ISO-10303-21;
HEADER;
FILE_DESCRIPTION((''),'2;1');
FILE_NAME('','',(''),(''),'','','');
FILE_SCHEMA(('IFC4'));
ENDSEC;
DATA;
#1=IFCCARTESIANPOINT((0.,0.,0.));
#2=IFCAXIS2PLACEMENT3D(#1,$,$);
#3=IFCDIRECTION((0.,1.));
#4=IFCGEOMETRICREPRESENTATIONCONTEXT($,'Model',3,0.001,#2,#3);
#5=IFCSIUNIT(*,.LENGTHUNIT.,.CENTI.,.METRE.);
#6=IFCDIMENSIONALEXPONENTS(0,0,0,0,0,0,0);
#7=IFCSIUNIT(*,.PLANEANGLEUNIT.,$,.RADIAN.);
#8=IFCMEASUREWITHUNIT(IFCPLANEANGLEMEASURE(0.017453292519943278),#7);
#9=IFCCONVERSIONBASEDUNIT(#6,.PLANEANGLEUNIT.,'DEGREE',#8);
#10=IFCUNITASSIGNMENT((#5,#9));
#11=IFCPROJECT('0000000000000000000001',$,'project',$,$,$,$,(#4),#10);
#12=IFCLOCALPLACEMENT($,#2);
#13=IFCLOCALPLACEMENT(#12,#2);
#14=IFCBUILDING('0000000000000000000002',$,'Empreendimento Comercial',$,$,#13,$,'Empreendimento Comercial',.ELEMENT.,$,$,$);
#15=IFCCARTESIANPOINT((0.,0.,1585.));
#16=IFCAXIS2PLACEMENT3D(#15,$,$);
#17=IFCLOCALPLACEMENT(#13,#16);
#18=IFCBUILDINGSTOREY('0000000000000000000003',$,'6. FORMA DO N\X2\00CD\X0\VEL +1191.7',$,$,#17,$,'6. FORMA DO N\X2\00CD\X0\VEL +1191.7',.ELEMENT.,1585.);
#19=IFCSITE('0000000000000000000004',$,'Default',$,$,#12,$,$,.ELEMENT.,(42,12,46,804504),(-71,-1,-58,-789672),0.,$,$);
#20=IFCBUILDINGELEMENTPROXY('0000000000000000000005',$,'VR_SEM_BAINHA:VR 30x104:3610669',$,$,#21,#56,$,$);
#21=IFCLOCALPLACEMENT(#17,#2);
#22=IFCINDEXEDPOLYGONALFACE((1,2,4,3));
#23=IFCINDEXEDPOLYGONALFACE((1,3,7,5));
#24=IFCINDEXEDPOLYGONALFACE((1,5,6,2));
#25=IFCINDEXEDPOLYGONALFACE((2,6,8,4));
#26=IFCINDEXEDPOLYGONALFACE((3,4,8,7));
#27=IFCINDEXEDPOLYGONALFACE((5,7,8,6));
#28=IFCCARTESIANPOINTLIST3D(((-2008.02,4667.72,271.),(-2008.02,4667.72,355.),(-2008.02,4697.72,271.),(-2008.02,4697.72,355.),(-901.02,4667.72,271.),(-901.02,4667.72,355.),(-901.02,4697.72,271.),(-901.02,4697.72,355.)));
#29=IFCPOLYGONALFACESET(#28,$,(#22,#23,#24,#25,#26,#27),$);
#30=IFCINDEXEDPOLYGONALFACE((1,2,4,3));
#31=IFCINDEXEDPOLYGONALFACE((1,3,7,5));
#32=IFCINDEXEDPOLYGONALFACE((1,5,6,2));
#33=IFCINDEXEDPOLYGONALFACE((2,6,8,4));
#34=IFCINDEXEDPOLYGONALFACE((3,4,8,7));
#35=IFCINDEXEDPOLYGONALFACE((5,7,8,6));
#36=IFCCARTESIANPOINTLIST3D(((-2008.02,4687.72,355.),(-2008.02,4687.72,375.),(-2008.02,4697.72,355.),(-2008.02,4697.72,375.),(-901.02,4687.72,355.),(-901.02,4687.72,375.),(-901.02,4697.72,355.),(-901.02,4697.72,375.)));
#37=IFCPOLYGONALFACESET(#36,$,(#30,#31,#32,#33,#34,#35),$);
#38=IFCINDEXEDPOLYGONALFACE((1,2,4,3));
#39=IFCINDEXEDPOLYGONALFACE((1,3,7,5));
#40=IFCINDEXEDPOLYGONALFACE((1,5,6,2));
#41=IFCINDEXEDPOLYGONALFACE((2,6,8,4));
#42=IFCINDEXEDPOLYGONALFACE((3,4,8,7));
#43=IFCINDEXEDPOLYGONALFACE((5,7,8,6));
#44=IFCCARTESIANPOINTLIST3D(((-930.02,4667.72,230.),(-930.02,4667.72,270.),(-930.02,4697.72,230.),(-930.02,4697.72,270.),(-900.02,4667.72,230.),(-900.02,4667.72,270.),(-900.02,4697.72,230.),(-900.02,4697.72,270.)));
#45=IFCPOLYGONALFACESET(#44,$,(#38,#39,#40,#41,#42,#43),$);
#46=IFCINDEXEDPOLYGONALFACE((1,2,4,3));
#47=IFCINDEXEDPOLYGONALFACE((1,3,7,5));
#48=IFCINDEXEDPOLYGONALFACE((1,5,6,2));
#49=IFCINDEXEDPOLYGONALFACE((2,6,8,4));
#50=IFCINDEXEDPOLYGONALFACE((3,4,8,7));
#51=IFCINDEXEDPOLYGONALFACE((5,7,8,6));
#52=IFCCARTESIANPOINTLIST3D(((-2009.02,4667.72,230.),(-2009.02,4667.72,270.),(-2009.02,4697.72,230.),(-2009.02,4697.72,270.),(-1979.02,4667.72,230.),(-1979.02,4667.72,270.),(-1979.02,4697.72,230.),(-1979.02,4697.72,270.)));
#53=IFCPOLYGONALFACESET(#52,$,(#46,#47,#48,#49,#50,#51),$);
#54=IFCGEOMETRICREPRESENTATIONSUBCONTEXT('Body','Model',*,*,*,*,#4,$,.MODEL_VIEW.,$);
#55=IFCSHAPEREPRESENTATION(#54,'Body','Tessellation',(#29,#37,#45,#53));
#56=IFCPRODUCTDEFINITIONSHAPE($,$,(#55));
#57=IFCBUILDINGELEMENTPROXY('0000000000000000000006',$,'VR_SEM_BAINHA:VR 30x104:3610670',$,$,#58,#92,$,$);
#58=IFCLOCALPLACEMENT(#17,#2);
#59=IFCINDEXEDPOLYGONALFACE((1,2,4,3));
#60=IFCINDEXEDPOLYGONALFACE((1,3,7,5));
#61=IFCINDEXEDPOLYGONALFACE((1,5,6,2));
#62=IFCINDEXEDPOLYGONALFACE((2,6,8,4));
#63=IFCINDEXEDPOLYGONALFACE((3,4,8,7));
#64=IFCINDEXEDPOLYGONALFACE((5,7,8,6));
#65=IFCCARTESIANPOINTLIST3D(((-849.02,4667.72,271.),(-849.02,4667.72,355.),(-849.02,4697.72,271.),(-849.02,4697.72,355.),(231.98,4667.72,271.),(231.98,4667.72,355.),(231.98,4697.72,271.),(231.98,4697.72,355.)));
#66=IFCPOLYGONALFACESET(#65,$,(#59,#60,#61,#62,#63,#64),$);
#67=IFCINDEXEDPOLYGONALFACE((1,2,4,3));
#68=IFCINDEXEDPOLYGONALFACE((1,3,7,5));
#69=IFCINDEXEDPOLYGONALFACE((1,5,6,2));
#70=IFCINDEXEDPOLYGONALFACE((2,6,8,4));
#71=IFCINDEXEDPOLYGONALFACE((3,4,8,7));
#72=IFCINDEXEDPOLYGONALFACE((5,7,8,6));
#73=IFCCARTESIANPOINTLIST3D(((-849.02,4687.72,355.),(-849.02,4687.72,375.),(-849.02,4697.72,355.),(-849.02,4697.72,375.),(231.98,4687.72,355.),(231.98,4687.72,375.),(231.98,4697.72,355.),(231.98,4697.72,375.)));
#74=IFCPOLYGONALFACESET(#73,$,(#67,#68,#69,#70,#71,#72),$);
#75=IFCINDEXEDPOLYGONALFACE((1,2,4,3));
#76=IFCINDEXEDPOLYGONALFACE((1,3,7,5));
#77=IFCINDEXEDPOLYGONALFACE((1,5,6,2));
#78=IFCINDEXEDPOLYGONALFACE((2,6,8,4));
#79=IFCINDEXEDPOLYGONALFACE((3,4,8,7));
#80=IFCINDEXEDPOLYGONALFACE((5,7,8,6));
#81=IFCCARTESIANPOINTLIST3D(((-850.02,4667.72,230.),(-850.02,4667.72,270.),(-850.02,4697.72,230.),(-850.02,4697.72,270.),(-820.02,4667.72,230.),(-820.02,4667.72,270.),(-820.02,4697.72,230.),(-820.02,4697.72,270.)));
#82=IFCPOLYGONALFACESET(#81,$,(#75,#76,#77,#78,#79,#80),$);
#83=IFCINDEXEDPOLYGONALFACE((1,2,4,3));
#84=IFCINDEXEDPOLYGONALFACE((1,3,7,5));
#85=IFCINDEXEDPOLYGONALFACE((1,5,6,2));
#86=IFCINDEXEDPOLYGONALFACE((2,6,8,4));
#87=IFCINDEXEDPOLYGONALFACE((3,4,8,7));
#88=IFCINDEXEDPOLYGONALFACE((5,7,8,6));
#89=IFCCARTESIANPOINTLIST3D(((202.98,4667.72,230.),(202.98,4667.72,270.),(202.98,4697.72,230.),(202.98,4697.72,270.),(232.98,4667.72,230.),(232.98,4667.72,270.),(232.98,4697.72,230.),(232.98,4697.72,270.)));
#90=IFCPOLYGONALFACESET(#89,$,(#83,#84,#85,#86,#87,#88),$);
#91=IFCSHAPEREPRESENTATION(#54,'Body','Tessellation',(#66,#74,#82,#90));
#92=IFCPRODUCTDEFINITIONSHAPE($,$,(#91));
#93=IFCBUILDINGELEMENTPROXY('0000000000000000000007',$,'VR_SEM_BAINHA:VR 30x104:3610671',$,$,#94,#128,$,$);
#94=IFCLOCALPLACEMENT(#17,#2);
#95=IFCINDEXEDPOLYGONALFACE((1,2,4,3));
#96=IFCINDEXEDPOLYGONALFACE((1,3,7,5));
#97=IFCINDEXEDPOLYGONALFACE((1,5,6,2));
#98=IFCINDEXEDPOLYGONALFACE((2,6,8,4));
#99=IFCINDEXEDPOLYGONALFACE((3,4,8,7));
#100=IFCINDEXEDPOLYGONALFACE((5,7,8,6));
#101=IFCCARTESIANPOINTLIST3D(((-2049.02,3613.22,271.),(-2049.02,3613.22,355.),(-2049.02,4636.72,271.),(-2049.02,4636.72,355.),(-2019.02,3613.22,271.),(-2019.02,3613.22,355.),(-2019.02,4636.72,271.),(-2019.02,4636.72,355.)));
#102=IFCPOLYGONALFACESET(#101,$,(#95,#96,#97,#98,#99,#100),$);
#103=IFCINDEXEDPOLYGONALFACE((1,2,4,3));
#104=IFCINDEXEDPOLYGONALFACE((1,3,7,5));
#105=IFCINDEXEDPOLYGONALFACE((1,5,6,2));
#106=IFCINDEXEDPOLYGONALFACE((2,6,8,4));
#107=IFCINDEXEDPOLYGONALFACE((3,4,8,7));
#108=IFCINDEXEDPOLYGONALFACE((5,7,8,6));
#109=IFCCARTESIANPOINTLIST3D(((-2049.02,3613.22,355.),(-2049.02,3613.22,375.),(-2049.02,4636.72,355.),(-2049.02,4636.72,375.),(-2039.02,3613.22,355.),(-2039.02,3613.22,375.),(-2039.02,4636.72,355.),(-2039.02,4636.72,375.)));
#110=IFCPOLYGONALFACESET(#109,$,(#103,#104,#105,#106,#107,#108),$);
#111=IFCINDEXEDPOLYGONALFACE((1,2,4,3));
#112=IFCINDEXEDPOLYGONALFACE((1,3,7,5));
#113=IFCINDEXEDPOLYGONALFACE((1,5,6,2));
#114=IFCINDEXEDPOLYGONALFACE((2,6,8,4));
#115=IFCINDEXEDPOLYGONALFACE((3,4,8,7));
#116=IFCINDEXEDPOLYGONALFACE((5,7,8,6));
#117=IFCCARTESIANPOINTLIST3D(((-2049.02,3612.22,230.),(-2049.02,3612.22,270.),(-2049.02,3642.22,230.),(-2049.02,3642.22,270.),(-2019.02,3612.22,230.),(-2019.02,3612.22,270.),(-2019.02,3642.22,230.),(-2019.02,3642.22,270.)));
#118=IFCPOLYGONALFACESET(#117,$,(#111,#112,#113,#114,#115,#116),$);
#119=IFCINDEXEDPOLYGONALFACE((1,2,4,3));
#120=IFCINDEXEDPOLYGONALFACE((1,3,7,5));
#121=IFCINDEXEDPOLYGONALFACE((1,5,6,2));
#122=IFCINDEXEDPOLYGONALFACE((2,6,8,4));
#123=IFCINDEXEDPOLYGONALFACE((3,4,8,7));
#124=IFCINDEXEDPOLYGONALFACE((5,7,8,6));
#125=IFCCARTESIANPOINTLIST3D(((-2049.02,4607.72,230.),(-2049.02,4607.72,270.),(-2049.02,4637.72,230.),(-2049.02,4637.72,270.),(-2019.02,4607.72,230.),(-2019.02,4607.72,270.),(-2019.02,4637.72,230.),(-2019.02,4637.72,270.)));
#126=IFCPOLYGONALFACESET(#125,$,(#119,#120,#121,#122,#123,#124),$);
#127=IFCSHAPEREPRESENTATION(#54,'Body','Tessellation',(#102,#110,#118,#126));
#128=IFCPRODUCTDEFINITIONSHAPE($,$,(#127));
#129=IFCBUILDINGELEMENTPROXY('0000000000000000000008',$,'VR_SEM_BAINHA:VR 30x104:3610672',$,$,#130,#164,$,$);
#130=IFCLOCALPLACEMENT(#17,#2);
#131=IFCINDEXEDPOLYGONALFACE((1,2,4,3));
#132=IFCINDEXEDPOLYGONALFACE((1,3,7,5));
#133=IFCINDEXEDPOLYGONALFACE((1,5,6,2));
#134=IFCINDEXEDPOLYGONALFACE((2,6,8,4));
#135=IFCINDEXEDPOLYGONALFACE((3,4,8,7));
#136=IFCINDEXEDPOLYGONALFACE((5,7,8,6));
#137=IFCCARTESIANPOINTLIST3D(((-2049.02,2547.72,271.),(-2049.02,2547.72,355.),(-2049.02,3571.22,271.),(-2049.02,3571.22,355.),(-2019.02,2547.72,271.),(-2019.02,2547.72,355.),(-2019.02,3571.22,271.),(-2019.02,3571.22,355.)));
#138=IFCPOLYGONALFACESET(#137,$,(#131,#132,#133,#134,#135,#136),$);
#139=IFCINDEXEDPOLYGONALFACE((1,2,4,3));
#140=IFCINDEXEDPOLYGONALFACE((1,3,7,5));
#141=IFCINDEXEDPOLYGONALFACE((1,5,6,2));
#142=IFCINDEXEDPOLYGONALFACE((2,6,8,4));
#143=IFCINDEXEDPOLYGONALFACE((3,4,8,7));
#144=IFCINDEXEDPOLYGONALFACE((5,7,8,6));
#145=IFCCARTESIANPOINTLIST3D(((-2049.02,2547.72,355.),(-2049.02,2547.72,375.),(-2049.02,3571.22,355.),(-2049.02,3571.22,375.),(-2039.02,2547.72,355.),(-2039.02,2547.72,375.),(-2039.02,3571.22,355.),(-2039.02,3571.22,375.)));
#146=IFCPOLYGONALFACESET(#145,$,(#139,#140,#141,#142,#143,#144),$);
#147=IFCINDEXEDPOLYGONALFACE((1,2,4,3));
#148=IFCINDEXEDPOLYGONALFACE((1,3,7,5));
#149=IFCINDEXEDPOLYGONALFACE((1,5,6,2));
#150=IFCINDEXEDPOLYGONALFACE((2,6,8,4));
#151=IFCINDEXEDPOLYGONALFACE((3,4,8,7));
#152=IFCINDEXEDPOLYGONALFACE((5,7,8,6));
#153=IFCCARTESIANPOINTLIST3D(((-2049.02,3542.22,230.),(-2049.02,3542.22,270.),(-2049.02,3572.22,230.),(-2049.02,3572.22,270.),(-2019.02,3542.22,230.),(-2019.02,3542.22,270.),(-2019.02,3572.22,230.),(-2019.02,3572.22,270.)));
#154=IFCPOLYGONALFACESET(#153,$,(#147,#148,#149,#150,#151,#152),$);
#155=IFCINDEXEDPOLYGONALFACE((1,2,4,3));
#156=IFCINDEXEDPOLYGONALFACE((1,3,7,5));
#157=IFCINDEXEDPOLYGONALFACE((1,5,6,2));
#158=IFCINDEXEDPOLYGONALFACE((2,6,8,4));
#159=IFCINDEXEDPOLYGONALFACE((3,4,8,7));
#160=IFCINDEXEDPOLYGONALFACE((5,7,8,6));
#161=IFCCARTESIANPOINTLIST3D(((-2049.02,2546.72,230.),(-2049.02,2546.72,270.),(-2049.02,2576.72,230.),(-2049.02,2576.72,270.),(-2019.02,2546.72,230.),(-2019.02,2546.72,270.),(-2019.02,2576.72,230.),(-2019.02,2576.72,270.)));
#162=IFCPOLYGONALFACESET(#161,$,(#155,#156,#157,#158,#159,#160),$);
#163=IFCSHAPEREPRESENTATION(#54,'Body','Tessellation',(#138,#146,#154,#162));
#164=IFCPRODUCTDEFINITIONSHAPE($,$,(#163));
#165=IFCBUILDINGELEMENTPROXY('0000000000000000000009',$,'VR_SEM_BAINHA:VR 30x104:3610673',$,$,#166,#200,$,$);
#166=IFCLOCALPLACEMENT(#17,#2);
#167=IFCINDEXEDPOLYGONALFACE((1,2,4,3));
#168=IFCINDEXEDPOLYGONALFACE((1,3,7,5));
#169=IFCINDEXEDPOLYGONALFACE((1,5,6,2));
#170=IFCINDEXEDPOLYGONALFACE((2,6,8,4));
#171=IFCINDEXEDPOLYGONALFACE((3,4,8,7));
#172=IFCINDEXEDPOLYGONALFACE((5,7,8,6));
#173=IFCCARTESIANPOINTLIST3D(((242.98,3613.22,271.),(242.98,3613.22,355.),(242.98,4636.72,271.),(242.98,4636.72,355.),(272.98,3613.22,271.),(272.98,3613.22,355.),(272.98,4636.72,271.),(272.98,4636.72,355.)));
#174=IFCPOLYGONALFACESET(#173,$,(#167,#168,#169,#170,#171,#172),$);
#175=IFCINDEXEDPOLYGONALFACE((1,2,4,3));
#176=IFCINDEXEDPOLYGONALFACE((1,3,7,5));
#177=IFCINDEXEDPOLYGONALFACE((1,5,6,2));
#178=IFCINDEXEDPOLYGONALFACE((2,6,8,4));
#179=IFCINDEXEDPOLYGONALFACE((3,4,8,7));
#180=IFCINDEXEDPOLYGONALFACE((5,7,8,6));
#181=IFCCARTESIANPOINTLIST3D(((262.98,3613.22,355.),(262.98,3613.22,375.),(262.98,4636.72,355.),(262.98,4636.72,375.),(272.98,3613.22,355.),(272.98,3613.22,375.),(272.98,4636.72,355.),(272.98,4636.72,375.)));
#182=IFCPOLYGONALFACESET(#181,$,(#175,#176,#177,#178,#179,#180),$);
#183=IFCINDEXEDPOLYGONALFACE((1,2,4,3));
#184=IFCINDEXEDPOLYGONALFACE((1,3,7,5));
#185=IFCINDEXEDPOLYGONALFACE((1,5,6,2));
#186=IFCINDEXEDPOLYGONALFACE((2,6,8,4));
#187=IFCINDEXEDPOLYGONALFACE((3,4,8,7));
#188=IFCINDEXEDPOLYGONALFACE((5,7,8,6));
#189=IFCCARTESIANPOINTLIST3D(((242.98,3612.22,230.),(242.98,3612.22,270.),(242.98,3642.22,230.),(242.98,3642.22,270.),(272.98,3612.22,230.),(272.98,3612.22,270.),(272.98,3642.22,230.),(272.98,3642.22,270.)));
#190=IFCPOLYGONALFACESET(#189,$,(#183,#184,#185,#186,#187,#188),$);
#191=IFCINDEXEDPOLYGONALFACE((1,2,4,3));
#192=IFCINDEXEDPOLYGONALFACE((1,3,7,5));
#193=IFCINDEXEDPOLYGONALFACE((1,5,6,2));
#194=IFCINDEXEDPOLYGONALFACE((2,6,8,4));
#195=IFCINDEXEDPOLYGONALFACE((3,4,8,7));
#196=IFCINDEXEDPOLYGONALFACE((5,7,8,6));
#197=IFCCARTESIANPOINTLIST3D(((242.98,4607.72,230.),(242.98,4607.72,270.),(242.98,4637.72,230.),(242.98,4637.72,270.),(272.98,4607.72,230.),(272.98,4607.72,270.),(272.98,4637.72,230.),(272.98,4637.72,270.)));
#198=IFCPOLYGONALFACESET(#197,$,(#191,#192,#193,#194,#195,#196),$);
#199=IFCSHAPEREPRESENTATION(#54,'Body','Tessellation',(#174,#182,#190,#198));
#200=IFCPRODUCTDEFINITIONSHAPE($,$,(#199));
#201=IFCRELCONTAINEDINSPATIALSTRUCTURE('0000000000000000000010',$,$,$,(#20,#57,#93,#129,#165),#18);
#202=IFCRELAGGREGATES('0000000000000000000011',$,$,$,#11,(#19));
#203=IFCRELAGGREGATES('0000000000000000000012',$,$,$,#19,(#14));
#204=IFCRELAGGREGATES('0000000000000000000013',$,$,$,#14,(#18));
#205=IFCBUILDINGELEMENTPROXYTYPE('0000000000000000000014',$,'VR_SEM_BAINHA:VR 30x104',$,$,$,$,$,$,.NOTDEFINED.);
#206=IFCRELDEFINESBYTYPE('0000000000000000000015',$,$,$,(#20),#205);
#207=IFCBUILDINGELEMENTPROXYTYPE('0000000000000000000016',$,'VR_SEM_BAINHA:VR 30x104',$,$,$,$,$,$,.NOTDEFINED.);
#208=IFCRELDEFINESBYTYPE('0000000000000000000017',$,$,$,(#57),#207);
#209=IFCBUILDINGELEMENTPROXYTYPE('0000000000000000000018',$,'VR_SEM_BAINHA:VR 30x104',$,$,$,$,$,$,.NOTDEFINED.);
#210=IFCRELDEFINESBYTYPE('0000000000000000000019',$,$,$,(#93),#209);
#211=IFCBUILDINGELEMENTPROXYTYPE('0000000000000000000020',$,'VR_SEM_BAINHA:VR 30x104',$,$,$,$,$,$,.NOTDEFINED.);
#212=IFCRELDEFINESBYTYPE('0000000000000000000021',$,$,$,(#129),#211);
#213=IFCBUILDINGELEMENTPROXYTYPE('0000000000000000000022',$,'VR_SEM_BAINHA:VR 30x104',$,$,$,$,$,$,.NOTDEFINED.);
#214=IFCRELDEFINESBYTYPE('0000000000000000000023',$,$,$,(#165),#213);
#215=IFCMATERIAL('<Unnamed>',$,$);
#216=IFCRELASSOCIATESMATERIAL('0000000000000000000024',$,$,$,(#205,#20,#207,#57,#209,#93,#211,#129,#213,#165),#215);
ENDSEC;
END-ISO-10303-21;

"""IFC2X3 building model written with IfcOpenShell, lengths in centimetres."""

from ifc_helpers import new_model, entity, si_unit, converted_unit, direction, frame, frame_2d, origin, origin_2d_with_axis, place, context, subcontext, project, spatial, rectangle, extrude, source, transform, mapped, material, type_object, type_shapes, element, save


model = new_model("IFC2X3")

# Units and contexts
model_context = context("Model", 3, precision=0.001, world=origin(), true_north=direction((0.0, 1.0)))
body_context = subcontext(model_context, "Body", "Model", "MODEL_VIEW")
ifc_project = project(units=[si_unit("LENGTHUNIT", "METRE", prefix="CENTI"), converted_unit("PLANEANGLEUNIT", "DEGREE", entity("IfcPlaneAngleMeasure", 0.017453292519943278), si_unit("PLANEANGLEUNIT", "RADIAN"), dimensions=[0, 0, 0, 0, 0, 0, 0])], contexts=[model_context])

# Site, building, storey
site_placement = place(None, origin())
site = spatial("IfcSite", under=ifc_project, at=site_placement, Name="Default", CompositionType="ELEMENT", RefLatitude=(42, 12, 46, 804504), RefLongitude=(-71, -1, -58, -789672), RefElevation=0.0)
building_placement = place(site_placement, origin())
building = spatial("IfcBuilding", under=site, at=building_placement, Name="Empreendimento Comercial", LongName="Empreendimento Comercial", CompositionType="ELEMENT")
storey_placement = place(building_placement, frame((0.0, 0.0, 1585.0)))
storey = spatial("IfcBuildingStorey", under=building, at=storey_placement, Name="6. FORMA DO NÍVEL +1191.7", LongName="6. FORMA DO NÍVEL +1191.7", CompositionType="ELEMENT", Elevation=1585.0)

# Shared definitions
ifc_material = material(Name="<Unnamed>")

# Building element proxies
building_element_proxy_type_1 = type_object("IfcBuildingElementProxyType", Name="VR_SEM_BAINHA:VR 30x104", PredefinedType="NOTDEFINED", material=ifc_material)
shared_shape_1 = source(origin(), body_context, "Body", "SweptSolid", [
    extrude(rectangle(XDim=30.0, YDim=1107.0, at=frame_2d((0.0, 0.0), x_axis=(1.0, 0.0))), frame((-1454.52, 4682.72, 1856.0), z_axis=(0.0, 0.0, 1.0), x_axis=(0.0, -1.0, 0.0)), (0.0, 0.0, 1.0), 84.0),
    extrude(rectangle(XDim=10.0, YDim=1107.0, at=frame_2d((0.0, 0.0), x_axis=(1.0, 0.0))), frame((-1454.52, 4692.72, 1940.0), z_axis=(0.0, 0.0, 1.0), x_axis=(0.0, -1.0, 0.0)), (0.0, 0.0, 1.0), 20.0),
    extrude(rectangle(XDim=30.0, YDim=30.0, at=frame_2d((0.0, 0.0), x_axis=(1.0, 0.0))), frame((-915.02, 4682.72, 1815.0)), (0.0, 0.0, 1.0), 40.0),
    extrude(rectangle(XDim=30.0, YDim=30.0, at=origin_2d_with_axis()), frame((-1994.02, 4682.72, 1815.0)), (0.0, 0.0, 1.0), 40.0),
])
type_shapes(building_element_proxy_type_1, [shared_shape_1])
proxy_1_placement = place(storey_placement, frame((0.0, 0.0, -1585.0)))
element("IfcBuildingElementProxy", 1, at=proxy_1_placement, inside=storey, type_object=building_element_proxy_type_1, material=ifc_material, Name="VR_SEM_BAINHA:VR 30x104:3610669", context=body_context, shape_type="MappedRepresentation", body=[
    mapped(shared_shape_1, transform((0.0, 0.0, 0.0), scale=1.0)),
])
building_element_proxy_type_2 = type_object("IfcBuildingElementProxyType", Name="VR_SEM_BAINHA:VR 30x104", PredefinedType="NOTDEFINED", material=ifc_material)
shared_shape_2 = source(origin(), body_context, "Body", "SweptSolid", [
    extrude(rectangle(XDim=1081.0, YDim=30.0, at=frame_2d((0.0, 0.0), x_axis=(1.0, 0.0))), frame((-308.52, 4682.72, 1856.0), z_axis=(0.0, 0.0, 1.0), x_axis=(-1.0, 0.0, 0.0)), (0.0, 0.0, 1.0), 84.0),
    extrude(rectangle(XDim=1081.0, YDim=10.0, at=origin_2d_with_axis()), frame((-308.52, 4692.72, 1940.0), z_axis=(0.0, 0.0, 1.0), x_axis=(-1.0, 0.0, 0.0)), (0.0, 0.0, 1.0), 20.0),
    extrude(rectangle(XDim=30.0, YDim=30.0, at=origin_2d_with_axis()), frame((-835.02, 4682.72, 1815.0), z_axis=(0.0, 0.0, 1.0), x_axis=(0.0, 1.0, 0.0)), (0.0, 0.0, 1.0), 40.0),
    extrude(rectangle(XDim=30.0, YDim=30.0, at=origin_2d_with_axis()), frame((217.98, 4682.72, 1815.0), z_axis=(0.0, 0.0, 1.0), x_axis=(0.0, 1.0, 0.0)), (0.0, 0.0, 1.0), 40.0),
])
type_shapes(building_element_proxy_type_2, [shared_shape_2])
proxy_2_placement = place(storey_placement, frame((0.0, 0.0, -1585.0)))
element("IfcBuildingElementProxy", 2, at=proxy_2_placement, inside=storey, type_object=building_element_proxy_type_2, material=ifc_material, Name="VR_SEM_BAINHA:VR 30x104:3610670", context=body_context, shape_type="MappedRepresentation", body=[
    mapped(shared_shape_2, transform((0.0, 0.0, 0.0), scale=1.0)),
])
building_element_proxy_type_3 = type_object("IfcBuildingElementProxyType", Name="VR_SEM_BAINHA:VR 30x104", PredefinedType="NOTDEFINED", material=ifc_material)
shared_shape_3 = source(origin(), body_context, "Body", "SweptSolid", [
    extrude(rectangle(XDim=1023.5, YDim=30.0, at=frame_2d((0.0, 0.0), x_axis=(1.0, 0.0))), frame((-2034.02, 4124.97, 1856.0), z_axis=(0.0, 0.0, 1.0), x_axis=(0.0, -1.0, 0.0)), (0.0, 0.0, 1.0), 84.0),
    extrude(rectangle(XDim=1023.5, YDim=10.0, at=frame_2d((0.0, 0.0), x_axis=(1.0, 0.0))), frame((-2044.02, 4124.97, 1940.0), z_axis=(0.0, 0.0, 1.0), x_axis=(0.0, -1.0, 0.0)), (0.0, 0.0, 1.0), 20.0),
    extrude(rectangle(XDim=30.0, YDim=30.0, at=frame_2d((0.0, 0.0), x_axis=(1.0, 0.0))), frame((-2034.02, 3627.22, 1815.0), z_axis=(0.0, 0.0, 1.0), x_axis=(-1.0, 0.0, 0.0)), (0.0, 0.0, 1.0), 40.0),
    extrude(rectangle(XDim=30.0, YDim=30.0, at=frame_2d((0.0, 0.0), x_axis=(1.0, 0.0))), frame((-2034.02, 4622.72, 1815.0), z_axis=(0.0, 0.0, 1.0), x_axis=(-1.0, 0.0, 0.0)), (0.0, 0.0, 1.0), 40.0),
])
type_shapes(building_element_proxy_type_3, [shared_shape_3])
proxy_3_placement = place(storey_placement, frame((0.0, 0.0, -1585.0)))
element("IfcBuildingElementProxy", 3, at=proxy_3_placement, inside=storey, type_object=building_element_proxy_type_3, material=ifc_material, Name="VR_SEM_BAINHA:VR 30x104:3610671", context=body_context, shape_type="MappedRepresentation", body=[
    mapped(shared_shape_3, transform((0.0, 0.0, 0.0), scale=1.0)),
])
building_element_proxy_type_4 = type_object("IfcBuildingElementProxyType", Name="VR_SEM_BAINHA:VR 30x104", PredefinedType="NOTDEFINED", material=ifc_material)
shared_shape_4 = source(origin(), body_context, "Body", "SweptSolid", [
    extrude(rectangle(XDim=30.0, YDim=1023.5, at=frame_2d((0.0, 0.0), x_axis=(1.0, 0.0))), frame((-2034.02, 3059.47, 1856.0)), (0.0, 0.0, 1.0), 84.0),
    extrude(rectangle(XDim=10.0, YDim=1023.5, at=frame_2d((0.0, 0.0), x_axis=(1.0, 0.0))), frame((-2044.02, 3059.47, 1940.0)), (0.0, 0.0, 1.0), 20.0),
    extrude(rectangle(XDim=30.0, YDim=30.0, at=frame_2d((0.0, 0.0), x_axis=(1.0, 0.0))), frame((-2034.02, 3557.22, 1815.0), z_axis=(0.0, 0.0, 1.0), x_axis=(0.0, 1.0, 0.0)), (0.0, 0.0, 1.0), 40.0),
    extrude(rectangle(XDim=30.0, YDim=30.0, at=origin_2d_with_axis()), frame((-2034.02, 2561.72, 1815.0), z_axis=(0.0, 0.0, 1.0), x_axis=(0.0, 1.0, 0.0)), (0.0, 0.0, 1.0), 40.0),
])
type_shapes(building_element_proxy_type_4, [shared_shape_4])
proxy_4_placement = place(storey_placement, frame((0.0, 0.0, -1585.0)))
element("IfcBuildingElementProxy", 4, at=proxy_4_placement, inside=storey, type_object=building_element_proxy_type_4, material=ifc_material, Name="VR_SEM_BAINHA:VR 30x104:3610672", context=body_context, shape_type="MappedRepresentation", body=[
    mapped(shared_shape_4, transform((0.0, 0.0, 0.0), scale=1.0)),
])
building_element_proxy_type_5 = type_object("IfcBuildingElementProxyType", Name="VR_SEM_BAINHA:VR 30x104", PredefinedType="NOTDEFINED", material=ifc_material)
shared_shape_5 = source(origin(), body_context, "Body", "SweptSolid", [
    extrude(rectangle(XDim=30.0, YDim=1023.5, at=frame_2d((0.0, 0.0), x_axis=(1.0, 0.0))), frame((257.98, 4124.97, 1856.0), z_axis=(0.0, 0.0, 1.0), x_axis=(-1.0, 0.0, 0.0)), (0.0, 0.0, 1.0), 84.0),
    extrude(rectangle(XDim=10.0, YDim=1023.5, at=frame_2d((0.0, 0.0), x_axis=(1.0, 0.0))), frame((267.98, 4124.97, 1940.0), z_axis=(0.0, 0.0, 1.0), x_axis=(-1.0, 0.0, 0.0)), (0.0, 0.0, 1.0), 20.0),
    extrude(rectangle(XDim=30.0, YDim=30.0, at=frame_2d((0.0, 0.0), x_axis=(1.0, 0.0))), frame((257.98, 3627.22, 1815.0), z_axis=(0.0, 0.0, 1.0), x_axis=(0.0, -1.0, 0.0)), (0.0, 0.0, 1.0), 40.0),
    extrude(rectangle(XDim=30.0, YDim=30.0, at=frame_2d((0.0, 0.0), x_axis=(1.0, 0.0))), frame((257.98, 4622.72, 1815.0), z_axis=(0.0, 0.0, 1.0), x_axis=(0.0, -1.0, 0.0)), (0.0, 0.0, 1.0), 40.0),
])
type_shapes(building_element_proxy_type_5, [shared_shape_5])
proxy_5_placement = place(storey_placement, frame((0.0, 0.0, -1585.0)))
element("IfcBuildingElementProxy", 5, at=proxy_5_placement, inside=storey, type_object=building_element_proxy_type_5, material=ifc_material, Name="VR_SEM_BAINHA:VR 30x104:3610673", context=body_context, shape_type="MappedRepresentation", body=[
    mapped(shared_shape_5, transform((0.0, 0.0, 0.0), scale=1.0)),
])

save(model, "model.ifc")
